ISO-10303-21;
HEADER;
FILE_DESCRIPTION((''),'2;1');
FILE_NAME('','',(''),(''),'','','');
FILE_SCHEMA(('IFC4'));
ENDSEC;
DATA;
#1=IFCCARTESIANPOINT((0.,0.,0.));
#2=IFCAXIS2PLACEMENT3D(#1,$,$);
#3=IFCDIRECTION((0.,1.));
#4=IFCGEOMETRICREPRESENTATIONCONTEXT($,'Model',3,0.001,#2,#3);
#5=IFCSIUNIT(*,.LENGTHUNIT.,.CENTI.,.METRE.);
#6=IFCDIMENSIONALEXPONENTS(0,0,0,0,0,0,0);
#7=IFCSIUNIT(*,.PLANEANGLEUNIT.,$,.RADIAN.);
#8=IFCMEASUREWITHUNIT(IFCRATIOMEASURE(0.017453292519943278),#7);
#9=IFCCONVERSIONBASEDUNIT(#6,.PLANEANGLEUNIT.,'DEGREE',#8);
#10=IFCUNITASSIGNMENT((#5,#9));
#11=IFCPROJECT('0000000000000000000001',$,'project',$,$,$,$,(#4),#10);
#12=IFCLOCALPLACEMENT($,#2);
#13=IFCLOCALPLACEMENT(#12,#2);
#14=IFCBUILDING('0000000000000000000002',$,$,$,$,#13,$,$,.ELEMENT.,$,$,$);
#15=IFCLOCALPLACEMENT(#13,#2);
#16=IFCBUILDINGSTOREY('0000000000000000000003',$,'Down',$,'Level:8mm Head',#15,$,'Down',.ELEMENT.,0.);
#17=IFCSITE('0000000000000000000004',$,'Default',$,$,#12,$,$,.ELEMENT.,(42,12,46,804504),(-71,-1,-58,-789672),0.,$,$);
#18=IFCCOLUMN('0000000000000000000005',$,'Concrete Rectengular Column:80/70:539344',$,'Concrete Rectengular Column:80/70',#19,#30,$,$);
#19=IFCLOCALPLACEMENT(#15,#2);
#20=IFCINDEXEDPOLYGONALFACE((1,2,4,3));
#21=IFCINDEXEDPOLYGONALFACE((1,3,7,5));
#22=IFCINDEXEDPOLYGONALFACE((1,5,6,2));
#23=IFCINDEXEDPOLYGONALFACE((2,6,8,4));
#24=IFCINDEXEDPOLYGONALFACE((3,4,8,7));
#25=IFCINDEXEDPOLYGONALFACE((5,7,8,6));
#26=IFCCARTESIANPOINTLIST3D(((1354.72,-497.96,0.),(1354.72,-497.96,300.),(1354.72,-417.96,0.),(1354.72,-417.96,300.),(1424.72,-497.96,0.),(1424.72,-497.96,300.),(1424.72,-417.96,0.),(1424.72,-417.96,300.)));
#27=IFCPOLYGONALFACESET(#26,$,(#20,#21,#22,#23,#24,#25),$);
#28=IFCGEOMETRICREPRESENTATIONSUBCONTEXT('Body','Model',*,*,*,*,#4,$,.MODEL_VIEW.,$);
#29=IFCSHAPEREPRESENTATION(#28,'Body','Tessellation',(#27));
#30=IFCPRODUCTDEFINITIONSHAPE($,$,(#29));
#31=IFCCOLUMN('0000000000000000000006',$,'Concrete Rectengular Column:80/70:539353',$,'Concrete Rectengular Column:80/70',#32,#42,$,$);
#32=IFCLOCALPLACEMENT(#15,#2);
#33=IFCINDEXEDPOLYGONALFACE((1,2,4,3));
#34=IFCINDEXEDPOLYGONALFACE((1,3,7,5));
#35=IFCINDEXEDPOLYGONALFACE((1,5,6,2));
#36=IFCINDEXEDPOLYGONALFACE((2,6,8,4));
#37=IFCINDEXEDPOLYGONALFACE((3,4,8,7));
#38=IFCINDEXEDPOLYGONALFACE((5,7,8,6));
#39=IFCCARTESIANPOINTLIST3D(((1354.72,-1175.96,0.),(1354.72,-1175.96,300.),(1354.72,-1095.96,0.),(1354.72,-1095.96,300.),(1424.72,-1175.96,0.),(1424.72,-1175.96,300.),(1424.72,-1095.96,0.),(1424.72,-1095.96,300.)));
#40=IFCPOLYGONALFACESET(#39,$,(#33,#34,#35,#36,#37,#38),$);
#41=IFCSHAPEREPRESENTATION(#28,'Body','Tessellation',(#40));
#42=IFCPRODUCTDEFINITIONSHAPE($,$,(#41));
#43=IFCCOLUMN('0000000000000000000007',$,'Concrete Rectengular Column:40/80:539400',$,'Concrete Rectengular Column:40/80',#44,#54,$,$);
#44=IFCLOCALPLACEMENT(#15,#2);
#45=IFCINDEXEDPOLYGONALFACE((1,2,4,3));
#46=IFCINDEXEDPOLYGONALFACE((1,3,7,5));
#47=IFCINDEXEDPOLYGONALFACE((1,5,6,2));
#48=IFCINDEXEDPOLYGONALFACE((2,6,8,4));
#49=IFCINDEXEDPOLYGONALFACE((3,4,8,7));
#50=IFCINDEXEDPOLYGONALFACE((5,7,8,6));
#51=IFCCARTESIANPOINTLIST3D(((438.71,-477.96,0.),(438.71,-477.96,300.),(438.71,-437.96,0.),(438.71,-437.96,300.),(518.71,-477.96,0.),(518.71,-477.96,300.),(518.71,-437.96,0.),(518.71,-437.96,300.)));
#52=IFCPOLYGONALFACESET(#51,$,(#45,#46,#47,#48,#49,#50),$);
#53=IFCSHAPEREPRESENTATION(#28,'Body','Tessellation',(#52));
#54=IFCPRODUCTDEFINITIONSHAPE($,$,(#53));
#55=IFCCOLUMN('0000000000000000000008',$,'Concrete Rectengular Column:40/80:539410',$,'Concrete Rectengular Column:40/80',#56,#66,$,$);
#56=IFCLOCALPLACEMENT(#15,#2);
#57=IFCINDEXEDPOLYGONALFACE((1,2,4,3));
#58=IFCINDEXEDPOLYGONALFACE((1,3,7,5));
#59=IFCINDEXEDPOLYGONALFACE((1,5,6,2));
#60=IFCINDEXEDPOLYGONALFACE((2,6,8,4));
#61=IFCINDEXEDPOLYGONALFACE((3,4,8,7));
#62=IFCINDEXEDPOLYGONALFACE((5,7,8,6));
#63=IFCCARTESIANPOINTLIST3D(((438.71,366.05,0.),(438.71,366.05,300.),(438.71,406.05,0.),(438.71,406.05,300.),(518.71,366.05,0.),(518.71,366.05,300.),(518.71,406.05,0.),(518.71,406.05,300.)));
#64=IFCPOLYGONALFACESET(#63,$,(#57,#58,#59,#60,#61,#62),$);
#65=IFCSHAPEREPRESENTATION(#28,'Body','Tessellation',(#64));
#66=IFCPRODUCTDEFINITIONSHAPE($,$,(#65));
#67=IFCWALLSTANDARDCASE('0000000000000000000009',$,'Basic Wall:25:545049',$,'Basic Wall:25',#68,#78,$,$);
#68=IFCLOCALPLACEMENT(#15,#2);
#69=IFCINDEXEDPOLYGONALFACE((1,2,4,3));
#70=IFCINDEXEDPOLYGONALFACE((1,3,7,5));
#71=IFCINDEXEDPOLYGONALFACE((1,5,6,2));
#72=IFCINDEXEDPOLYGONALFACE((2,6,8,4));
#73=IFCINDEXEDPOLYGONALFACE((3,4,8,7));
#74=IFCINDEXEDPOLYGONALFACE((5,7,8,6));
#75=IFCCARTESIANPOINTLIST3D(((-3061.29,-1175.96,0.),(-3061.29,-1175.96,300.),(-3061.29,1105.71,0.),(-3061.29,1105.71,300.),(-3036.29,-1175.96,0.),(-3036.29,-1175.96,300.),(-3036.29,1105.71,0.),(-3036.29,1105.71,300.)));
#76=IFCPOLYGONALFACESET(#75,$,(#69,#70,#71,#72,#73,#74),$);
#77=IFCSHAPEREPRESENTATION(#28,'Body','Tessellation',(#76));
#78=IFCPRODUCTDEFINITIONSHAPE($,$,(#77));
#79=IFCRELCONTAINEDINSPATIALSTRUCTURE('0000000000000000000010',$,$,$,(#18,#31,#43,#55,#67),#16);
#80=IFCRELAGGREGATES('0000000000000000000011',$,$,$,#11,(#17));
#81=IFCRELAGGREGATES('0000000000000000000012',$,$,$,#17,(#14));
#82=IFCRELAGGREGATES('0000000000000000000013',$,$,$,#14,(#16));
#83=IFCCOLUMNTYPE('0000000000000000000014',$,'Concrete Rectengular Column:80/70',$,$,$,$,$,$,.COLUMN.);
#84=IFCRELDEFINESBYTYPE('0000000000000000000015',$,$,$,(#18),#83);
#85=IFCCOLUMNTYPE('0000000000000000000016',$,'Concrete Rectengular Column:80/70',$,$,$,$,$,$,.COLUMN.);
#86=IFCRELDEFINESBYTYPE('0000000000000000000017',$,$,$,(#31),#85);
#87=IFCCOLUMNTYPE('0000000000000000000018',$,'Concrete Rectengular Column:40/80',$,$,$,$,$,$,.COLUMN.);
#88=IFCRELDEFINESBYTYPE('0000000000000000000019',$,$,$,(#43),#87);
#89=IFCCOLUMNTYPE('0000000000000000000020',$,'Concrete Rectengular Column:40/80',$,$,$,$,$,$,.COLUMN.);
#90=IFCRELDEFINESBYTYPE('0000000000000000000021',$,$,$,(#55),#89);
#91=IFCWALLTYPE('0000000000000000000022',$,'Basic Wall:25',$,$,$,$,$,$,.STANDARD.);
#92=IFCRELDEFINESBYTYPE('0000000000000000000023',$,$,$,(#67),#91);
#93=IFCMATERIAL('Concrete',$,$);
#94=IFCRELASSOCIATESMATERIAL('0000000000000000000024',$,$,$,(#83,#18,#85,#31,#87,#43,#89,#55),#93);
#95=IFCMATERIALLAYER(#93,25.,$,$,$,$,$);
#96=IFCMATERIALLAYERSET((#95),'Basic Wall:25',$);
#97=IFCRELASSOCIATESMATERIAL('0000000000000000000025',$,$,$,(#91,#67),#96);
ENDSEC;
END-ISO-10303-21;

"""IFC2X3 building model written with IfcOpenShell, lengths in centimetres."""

from ifc_helpers import new_model, entity, si_unit, converted_unit, direction, frame, frame_2d, origin, origin_2d_with_axis, place, context, subcontext, project, spatial, rectangle, extrude, source, transform, mapped, material, layer, layer_set, layer_usage, type_object, type_shapes, element, save


model = new_model("IFC2X3")

# Units and contexts
model_context = context("Model", 3, precision=0.001, world=origin(), true_north=direction((0.0, 1.0)))
body_context = subcontext(model_context, "Body", "Model", "MODEL_VIEW")
ifc_project = project(units=[si_unit("LENGTHUNIT", "METRE", prefix="CENTI"), converted_unit("PLANEANGLEUNIT", "DEGREE", entity("IfcRatioMeasure", 0.017453292519943278), si_unit("PLANEANGLEUNIT", "RADIAN"), dimensions=[0, 0, 0, 0, 0, 0, 0])], contexts=[model_context])

# Site, building, storey
site_placement = place(None, origin())
site = spatial("IfcSite", under=ifc_project, at=site_placement, Name="Default", CompositionType="ELEMENT", RefLatitude=(42, 12, 46, 804504), RefLongitude=(-71, -1, -58, -789672), RefElevation=0.0)
building_placement = place(site_placement, origin())
building = spatial("IfcBuilding", under=site, at=building_placement, CompositionType="ELEMENT")
storey_placement = place(building_placement, origin())
storey = spatial("IfcBuildingStorey", under=building, at=storey_placement, Name="Down", ObjectType="Level:8mm Head", LongName="Down", CompositionType="ELEMENT", Elevation=0.0)

# Columns
ifc_material = material(Name="Concrete")
column_type_1 = type_object("IfcColumnType", Name="Concrete Rectengular Column:80/70", PredefinedType="COLUMN", material=ifc_material)
shared_shape_1 = source(origin(), body_context, "Body", "SweptSolid", [
    extrude(rectangle(XDim=80.0, YDim=70.0, at=frame_2d((0.0, 0.0), x_axis=(1.0, 0.0))), frame((1389.72, -457.96, 0.0), z_axis=(0.0, 0.0, 1.0), x_axis=(0.0, -1.0, 0.0)), (0.0, 0.0, 1.0), 300.0),
])
type_shapes(column_type_1, [shared_shape_1])
column_1_placement = place(storey_placement, origin())
element("IfcColumn", 1, at=column_1_placement, inside=storey, type_object=column_type_1, material=ifc_material, Name="Concrete Rectengular Column:80/70:539344", ObjectType="Concrete Rectengular Column:80/70", context=body_context, shape_type="MappedRepresentation", body=[
    mapped(shared_shape_1, transform((0.0, 0.0, 0.0), scale=1.0)),
])
column_type_2 = type_object("IfcColumnType", Name="Concrete Rectengular Column:80/70", PredefinedType="COLUMN", material=ifc_material)
shared_shape_2 = source(origin(), body_context, "Body", "SweptSolid", [
    extrude(rectangle(XDim=80.0, YDim=70.0, at=origin_2d_with_axis()), frame((1389.72, -1135.96, 0.0), z_axis=(0.0, 0.0, 1.0), x_axis=(0.0, -1.0, 0.0)), (0.0, 0.0, 1.0), 300.0),
])
type_shapes(column_type_2, [shared_shape_2])
column_2_placement = place(storey_placement, origin())
element("IfcColumn", 2, at=column_2_placement, inside=storey, type_object=column_type_2, material=ifc_material, Name="Concrete Rectengular Column:80/70:539353", ObjectType="Concrete Rectengular Column:80/70", context=body_context, shape_type="MappedRepresentation", body=[
    mapped(shared_shape_2, transform((0.0, 0.0, 0.0), scale=1.0)),
])
column_type_3 = type_object("IfcColumnType", Name="Concrete Rectengular Column:40/80", PredefinedType="COLUMN", material=ifc_material)
shared_shape_3 = source(origin(), body_context, "Body", "SweptSolid", [
    extrude(rectangle(XDim=40.0, YDim=80.0, at=origin_2d_with_axis()), frame((478.71, -457.96, 0.0), z_axis=(0.0, 0.0, 1.0), x_axis=(0.0, -1.0, 0.0)), (0.0, 0.0, 1.0), 300.0),
])
type_shapes(column_type_3, [shared_shape_3])
column_3_placement = place(storey_placement, origin())
element("IfcColumn", 3, at=column_3_placement, inside=storey, type_object=column_type_3, material=ifc_material, Name="Concrete Rectengular Column:40/80:539400", ObjectType="Concrete Rectengular Column:40/80", context=body_context, shape_type="MappedRepresentation", body=[
    mapped(shared_shape_3, transform((0.0, 0.0, 0.0), scale=1.0)),
])
column_type_4 = type_object("IfcColumnType", Name="Concrete Rectengular Column:40/80", PredefinedType="COLUMN", material=ifc_material)
shared_shape_4 = source(origin(), body_context, "Body", "SweptSolid", [
    extrude(rectangle(XDim=40.0, YDim=80.0, at=origin_2d_with_axis()), frame((478.71, 386.05, 0.0), z_axis=(0.0, 0.0, 1.0), x_axis=(0.0, -1.0, 0.0)), (0.0, 0.0, 1.0), 300.0),
])
type_shapes(column_type_4, [shared_shape_4])
column_4_placement = place(storey_placement, origin())
element("IfcColumn", 4, at=column_4_placement, inside=storey, type_object=column_type_4, material=ifc_material, Name="Concrete Rectengular Column:40/80:539410", ObjectType="Concrete Rectengular Column:40/80", context=body_context, shape_type="MappedRepresentation", body=[
    mapped(shared_shape_4, transform((0.0, 0.0, 0.0), scale=1.0)),
])

# Wall
ifc_layer = layer(ifc_material, 25.0)
ifc_layer_set = layer_set([ifc_layer], Name="Basic Wall:25")
ifc_layer_usage = layer_usage(ifc_layer_set, "AXIS2", "NEGATIVE", 12.5)
wall_type = type_object("IfcWallType", Name="Basic Wall:25", PredefinedType="STANDARD", material=ifc_layer_set)
wall_placement = place(storey_placement, frame((-3048.79, -1175.96, 0.0), z_axis=(0.0, 0.0, 1.0), x_axis=(0.0, 1.0, 0.0)))
element("IfcWallStandardCase", 5, at=wall_placement, inside=storey, type_object=wall_type, material=ifc_layer_usage, Name="Basic Wall:25:545049", ObjectType="Basic Wall:25", context=body_context, shape_type="SweptSolid", body=[
    extrude(rectangle(XDim=2281.67, YDim=25.0, at=frame_2d((1140.84, 0.0), x_axis=(-1.0, 0.0))), origin(), (0.0, 0.0, 1.0), 300.0),
])

save(model, "model.ifc")
